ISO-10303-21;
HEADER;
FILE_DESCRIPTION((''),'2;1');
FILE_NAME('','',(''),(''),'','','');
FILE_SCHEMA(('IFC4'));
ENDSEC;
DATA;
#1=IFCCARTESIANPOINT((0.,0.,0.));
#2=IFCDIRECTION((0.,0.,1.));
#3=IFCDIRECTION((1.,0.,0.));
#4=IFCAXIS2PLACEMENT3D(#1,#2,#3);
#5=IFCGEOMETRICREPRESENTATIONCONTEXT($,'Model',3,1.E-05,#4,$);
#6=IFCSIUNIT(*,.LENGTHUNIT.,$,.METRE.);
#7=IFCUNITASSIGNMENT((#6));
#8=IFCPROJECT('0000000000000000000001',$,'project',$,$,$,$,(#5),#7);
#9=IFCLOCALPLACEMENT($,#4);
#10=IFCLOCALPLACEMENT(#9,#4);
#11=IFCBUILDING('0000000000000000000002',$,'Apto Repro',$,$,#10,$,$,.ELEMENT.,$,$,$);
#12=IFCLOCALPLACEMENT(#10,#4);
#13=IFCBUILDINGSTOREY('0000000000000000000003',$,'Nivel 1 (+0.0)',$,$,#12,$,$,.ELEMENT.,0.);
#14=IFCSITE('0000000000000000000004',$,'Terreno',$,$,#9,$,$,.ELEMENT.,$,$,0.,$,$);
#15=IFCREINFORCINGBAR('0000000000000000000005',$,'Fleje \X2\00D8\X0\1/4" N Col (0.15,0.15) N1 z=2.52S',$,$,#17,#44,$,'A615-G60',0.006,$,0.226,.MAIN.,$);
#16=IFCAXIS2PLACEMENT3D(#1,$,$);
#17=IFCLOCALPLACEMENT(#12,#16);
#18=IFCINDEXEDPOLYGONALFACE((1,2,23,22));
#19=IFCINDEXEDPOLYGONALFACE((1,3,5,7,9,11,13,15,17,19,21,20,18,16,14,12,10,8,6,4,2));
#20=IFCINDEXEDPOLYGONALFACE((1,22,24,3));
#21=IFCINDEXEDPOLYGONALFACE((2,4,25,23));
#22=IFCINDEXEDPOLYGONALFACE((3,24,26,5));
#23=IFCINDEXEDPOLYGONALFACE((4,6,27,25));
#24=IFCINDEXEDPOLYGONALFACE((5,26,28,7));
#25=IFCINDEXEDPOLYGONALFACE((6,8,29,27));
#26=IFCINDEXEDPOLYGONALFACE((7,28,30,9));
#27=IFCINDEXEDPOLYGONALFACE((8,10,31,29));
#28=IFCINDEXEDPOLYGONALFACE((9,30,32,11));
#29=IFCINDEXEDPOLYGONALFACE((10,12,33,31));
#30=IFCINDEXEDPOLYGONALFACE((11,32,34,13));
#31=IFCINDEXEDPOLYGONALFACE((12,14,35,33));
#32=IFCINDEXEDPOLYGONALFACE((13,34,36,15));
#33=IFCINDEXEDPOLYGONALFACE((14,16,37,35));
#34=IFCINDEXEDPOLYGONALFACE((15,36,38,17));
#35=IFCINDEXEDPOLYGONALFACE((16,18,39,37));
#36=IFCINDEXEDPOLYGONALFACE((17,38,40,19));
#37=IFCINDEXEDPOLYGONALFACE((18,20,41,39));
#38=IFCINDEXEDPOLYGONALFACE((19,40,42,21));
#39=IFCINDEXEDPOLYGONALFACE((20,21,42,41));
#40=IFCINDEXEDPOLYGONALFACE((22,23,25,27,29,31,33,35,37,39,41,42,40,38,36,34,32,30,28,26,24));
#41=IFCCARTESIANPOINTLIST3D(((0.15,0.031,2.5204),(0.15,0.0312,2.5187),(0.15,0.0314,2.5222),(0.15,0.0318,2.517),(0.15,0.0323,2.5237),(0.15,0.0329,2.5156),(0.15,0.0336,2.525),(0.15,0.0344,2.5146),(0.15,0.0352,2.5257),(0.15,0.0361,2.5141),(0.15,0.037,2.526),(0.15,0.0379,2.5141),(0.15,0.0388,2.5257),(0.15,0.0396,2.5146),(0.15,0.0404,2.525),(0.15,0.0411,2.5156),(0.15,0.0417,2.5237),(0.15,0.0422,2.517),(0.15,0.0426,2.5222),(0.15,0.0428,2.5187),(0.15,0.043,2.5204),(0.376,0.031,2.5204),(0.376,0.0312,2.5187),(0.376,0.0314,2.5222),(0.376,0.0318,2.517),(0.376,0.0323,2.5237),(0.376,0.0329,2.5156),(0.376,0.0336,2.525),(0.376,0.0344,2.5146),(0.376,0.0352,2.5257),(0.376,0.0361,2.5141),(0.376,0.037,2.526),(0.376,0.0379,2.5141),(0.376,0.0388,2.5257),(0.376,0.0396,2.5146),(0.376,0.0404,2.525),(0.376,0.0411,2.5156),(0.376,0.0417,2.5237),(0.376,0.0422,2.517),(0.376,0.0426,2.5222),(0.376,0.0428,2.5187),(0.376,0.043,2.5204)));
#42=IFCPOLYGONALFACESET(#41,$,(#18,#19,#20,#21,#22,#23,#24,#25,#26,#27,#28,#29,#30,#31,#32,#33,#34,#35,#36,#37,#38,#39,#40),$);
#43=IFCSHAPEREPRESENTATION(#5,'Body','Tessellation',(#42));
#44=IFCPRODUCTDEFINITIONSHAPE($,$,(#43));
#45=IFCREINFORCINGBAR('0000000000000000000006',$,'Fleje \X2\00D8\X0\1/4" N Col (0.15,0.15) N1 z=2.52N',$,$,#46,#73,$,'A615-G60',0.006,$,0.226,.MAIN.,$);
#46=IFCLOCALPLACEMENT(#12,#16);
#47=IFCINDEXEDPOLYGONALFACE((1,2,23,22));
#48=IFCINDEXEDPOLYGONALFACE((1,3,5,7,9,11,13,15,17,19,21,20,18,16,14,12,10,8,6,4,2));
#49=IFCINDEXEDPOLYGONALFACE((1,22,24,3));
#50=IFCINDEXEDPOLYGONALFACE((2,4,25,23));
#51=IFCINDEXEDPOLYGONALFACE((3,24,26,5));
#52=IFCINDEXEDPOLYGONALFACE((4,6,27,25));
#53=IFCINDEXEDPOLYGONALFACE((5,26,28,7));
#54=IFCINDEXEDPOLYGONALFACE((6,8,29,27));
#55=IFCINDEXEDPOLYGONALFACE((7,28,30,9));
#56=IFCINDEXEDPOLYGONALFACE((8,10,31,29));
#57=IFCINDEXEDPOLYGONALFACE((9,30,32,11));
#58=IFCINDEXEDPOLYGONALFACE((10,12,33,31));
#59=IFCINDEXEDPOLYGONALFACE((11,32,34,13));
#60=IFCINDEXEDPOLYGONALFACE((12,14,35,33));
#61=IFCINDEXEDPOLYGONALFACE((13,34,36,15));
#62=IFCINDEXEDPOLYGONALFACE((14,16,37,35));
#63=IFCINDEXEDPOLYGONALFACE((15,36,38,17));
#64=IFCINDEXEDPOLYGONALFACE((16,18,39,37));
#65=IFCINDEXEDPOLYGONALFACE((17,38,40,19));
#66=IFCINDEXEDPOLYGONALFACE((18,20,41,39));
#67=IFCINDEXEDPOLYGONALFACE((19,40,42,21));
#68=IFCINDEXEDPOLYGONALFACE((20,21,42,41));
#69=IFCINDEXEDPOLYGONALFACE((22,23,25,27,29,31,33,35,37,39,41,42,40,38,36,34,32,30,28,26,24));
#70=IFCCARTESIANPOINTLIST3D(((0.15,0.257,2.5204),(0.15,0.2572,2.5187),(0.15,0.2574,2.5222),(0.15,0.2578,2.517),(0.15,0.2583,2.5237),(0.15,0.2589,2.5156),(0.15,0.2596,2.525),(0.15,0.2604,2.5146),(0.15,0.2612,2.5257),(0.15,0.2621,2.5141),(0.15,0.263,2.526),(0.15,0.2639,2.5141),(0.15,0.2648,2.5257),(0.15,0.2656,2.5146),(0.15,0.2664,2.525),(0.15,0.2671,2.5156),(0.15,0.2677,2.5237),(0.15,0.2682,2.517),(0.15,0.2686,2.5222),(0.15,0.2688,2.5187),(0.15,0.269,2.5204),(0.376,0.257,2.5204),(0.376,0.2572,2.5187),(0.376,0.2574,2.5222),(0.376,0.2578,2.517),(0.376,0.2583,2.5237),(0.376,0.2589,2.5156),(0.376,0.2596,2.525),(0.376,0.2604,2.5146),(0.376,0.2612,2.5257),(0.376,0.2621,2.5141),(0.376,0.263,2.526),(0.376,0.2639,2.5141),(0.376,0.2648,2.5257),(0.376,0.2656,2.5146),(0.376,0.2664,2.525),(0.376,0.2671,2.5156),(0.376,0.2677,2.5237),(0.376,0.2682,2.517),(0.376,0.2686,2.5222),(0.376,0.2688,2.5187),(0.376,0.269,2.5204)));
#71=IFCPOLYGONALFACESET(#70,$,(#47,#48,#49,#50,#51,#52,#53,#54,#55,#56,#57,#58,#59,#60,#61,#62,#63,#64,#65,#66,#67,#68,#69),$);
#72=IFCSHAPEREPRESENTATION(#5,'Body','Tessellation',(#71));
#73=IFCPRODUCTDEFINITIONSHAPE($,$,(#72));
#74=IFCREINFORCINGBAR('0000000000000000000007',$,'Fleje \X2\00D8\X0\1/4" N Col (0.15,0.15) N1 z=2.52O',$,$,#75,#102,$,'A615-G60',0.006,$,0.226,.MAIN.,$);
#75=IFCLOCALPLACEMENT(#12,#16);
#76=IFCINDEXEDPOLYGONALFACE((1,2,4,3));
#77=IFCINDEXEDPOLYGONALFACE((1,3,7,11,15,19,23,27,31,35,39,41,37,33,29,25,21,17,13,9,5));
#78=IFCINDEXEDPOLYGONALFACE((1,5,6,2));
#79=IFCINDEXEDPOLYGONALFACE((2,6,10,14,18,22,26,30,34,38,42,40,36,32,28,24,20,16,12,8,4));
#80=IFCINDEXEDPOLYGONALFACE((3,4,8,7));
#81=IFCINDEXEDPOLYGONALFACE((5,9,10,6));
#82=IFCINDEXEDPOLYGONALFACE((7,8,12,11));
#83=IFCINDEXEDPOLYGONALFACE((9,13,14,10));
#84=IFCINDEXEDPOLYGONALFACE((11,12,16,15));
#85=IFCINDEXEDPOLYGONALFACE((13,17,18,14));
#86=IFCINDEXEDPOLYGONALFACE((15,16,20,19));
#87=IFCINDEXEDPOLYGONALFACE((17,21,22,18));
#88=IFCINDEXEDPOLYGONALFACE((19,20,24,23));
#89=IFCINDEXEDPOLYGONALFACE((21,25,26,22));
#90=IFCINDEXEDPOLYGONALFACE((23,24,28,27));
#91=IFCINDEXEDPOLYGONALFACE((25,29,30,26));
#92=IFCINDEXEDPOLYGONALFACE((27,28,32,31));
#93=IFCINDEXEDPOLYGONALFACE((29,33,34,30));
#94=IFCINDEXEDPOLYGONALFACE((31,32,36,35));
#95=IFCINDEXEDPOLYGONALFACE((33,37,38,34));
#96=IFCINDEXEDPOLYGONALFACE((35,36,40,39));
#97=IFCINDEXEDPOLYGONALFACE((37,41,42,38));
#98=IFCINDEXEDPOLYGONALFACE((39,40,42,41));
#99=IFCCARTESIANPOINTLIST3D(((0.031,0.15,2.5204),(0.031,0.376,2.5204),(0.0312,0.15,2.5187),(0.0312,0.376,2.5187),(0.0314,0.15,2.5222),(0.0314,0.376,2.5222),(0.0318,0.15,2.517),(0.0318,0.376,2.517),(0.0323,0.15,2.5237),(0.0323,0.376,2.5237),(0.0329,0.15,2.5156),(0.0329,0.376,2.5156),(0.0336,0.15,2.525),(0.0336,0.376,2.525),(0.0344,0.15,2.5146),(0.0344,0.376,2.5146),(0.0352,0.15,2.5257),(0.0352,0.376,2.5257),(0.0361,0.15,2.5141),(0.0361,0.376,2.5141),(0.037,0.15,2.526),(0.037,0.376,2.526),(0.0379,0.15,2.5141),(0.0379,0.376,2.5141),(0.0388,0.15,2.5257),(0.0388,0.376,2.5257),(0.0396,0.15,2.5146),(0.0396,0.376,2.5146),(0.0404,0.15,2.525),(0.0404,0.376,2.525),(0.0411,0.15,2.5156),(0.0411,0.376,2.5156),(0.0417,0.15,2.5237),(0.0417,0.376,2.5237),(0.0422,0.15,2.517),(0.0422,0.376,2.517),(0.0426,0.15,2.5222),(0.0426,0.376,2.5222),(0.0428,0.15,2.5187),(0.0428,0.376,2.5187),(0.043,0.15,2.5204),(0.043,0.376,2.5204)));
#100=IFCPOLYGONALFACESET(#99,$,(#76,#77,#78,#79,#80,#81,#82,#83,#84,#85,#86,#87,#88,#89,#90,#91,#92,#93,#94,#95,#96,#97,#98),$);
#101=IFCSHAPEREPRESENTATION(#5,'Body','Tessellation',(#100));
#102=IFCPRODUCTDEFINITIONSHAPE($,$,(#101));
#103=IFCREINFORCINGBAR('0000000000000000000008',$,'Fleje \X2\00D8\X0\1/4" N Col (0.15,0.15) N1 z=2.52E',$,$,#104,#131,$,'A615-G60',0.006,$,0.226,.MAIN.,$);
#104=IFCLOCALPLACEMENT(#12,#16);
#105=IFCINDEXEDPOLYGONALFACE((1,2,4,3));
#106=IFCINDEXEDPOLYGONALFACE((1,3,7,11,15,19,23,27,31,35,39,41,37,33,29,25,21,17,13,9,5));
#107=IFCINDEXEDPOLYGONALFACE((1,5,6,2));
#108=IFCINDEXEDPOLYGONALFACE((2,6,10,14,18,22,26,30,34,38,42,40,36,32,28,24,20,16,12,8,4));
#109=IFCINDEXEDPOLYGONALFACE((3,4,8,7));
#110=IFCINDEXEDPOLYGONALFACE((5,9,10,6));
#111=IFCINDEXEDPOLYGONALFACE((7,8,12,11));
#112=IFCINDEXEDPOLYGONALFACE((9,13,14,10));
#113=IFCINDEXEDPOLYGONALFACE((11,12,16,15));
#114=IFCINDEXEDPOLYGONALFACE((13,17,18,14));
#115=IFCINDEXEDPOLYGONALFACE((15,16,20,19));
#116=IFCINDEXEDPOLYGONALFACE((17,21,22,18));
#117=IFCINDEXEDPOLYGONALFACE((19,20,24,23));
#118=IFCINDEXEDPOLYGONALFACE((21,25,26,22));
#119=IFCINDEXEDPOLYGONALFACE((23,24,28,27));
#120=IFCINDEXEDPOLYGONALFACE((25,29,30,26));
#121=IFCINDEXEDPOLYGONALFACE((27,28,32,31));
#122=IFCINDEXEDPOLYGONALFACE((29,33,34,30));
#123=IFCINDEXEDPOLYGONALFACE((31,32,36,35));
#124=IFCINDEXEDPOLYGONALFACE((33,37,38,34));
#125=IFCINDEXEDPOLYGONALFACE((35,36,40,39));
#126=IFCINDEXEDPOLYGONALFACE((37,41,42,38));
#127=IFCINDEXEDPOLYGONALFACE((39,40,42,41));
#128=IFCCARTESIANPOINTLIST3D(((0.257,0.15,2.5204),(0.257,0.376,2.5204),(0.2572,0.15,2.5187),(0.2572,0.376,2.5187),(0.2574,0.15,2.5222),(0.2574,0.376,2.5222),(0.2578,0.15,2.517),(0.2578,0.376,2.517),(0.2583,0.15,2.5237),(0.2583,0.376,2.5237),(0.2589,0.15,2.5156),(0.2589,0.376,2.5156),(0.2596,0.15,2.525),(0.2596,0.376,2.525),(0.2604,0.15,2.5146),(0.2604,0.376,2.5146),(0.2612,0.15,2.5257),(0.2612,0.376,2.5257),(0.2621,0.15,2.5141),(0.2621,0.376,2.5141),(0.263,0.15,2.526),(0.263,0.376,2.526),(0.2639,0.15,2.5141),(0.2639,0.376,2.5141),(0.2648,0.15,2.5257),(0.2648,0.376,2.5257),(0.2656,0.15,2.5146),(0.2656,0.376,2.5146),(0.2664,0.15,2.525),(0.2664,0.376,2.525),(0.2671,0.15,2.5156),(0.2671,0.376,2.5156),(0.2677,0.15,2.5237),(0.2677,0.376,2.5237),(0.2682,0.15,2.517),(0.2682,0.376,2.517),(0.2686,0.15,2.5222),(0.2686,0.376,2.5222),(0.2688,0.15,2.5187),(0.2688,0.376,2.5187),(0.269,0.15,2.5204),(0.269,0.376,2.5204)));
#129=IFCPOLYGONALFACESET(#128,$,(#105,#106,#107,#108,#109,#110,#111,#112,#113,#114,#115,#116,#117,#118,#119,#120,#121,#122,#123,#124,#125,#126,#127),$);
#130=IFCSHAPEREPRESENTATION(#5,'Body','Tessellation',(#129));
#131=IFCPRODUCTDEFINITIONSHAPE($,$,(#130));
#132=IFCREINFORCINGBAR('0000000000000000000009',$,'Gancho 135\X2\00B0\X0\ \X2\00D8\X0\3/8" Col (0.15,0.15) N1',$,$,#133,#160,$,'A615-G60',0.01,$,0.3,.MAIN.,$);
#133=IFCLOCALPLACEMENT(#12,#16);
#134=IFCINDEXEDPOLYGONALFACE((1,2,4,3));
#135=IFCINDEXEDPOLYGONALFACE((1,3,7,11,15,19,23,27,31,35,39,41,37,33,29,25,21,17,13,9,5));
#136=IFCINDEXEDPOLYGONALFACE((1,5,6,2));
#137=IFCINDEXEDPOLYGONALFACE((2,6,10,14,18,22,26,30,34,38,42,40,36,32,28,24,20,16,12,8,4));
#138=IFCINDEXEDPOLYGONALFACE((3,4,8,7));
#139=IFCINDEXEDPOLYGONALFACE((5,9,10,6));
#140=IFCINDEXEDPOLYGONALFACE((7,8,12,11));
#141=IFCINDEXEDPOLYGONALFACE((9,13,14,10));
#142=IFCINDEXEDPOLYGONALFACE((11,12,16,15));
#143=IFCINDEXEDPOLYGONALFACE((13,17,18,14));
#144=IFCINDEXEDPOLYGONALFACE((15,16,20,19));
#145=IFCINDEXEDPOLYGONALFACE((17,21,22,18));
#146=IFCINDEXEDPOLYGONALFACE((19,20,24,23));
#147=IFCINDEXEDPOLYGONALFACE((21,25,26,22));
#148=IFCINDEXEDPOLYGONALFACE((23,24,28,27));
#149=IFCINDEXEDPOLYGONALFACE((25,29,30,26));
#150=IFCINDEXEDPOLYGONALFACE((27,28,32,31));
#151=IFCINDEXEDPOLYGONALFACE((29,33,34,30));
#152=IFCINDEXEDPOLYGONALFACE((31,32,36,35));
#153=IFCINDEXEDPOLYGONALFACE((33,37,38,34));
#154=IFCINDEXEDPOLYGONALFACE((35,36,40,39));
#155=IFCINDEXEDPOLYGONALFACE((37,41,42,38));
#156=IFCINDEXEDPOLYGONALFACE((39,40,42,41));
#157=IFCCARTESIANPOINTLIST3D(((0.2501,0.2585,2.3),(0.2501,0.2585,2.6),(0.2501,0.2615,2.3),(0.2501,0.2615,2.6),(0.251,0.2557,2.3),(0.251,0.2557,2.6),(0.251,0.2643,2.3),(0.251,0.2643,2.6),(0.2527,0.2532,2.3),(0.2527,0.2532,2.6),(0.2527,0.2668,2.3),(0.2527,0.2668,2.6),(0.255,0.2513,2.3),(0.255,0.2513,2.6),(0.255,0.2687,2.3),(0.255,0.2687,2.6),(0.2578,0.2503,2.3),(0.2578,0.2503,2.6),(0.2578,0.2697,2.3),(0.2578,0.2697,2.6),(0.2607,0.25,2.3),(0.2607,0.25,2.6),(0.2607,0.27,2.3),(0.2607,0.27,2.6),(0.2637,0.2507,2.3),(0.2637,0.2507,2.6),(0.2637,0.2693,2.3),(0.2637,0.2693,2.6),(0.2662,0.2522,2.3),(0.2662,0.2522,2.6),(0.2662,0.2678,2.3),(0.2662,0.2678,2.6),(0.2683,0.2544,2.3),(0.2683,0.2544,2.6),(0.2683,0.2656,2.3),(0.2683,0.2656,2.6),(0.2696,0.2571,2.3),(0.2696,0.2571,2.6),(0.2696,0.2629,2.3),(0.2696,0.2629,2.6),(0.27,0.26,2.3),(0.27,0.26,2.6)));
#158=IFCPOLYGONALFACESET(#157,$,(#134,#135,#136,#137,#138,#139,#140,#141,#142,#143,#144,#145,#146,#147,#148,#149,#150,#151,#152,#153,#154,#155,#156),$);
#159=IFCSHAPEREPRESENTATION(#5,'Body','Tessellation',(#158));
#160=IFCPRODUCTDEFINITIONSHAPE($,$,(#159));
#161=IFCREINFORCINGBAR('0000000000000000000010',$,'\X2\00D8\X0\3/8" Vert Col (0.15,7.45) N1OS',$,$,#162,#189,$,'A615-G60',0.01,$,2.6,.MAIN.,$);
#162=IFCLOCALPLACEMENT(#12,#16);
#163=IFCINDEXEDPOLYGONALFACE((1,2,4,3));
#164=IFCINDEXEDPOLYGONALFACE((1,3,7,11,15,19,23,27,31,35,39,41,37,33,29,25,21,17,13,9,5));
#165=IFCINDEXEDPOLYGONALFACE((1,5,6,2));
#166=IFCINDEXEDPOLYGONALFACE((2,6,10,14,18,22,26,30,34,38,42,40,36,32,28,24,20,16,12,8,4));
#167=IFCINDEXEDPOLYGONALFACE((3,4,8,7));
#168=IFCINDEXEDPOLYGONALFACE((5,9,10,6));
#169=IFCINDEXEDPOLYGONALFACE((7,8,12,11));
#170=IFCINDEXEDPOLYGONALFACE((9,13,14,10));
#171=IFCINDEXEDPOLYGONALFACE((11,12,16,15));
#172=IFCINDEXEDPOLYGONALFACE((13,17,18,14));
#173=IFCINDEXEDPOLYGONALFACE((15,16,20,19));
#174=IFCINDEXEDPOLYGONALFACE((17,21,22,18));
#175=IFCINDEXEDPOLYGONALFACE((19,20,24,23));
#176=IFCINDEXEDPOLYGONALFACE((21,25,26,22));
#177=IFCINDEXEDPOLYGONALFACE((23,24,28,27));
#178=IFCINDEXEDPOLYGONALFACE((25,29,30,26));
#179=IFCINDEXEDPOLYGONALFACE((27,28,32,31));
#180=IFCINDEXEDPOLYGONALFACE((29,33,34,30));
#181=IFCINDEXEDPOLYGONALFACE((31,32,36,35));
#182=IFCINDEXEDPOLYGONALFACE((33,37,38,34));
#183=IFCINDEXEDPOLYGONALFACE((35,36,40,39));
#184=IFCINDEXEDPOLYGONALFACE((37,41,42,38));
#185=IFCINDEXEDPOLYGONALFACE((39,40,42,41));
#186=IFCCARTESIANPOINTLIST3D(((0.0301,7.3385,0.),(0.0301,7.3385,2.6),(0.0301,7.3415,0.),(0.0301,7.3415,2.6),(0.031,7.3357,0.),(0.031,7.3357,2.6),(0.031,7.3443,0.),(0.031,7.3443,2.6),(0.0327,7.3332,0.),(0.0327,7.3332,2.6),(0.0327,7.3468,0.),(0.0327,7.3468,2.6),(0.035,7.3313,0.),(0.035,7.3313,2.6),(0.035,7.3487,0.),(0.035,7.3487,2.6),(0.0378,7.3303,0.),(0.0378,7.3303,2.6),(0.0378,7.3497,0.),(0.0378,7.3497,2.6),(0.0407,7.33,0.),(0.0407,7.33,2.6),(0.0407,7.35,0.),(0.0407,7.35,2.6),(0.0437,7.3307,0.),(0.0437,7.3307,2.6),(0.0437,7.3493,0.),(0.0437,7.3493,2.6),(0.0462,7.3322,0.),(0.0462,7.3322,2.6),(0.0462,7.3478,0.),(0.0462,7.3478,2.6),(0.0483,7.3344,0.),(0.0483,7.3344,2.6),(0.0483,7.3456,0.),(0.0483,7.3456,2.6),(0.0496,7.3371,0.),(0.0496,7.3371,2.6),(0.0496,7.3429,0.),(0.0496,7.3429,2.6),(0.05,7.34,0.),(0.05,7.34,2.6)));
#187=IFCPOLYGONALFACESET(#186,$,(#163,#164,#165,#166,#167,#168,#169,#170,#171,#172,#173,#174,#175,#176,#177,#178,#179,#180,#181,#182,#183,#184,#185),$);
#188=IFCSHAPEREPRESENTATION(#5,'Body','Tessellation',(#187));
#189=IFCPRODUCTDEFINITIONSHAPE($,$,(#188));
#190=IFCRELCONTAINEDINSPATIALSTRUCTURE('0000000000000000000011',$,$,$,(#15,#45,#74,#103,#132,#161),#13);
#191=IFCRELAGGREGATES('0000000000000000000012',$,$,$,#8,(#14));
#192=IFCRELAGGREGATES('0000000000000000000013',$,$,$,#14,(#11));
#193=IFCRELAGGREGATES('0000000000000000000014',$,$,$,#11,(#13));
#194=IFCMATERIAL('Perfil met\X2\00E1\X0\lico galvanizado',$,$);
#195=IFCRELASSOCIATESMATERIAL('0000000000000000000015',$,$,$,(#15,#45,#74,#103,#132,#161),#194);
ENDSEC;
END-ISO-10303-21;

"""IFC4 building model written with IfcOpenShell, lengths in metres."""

from ifc_helpers import new_model, si_unit, frame, origin_with_axes, origin_2d_with_axis, place, context, project, spatial, circle, extrude, material, element, save


model = new_model("IFC4")

# Units and contexts
model_context = context("Model", 3, precision=1e-05, world=origin_with_axes())
ifc_project = project(units=[si_unit("LENGTHUNIT", "METRE")], contexts=[model_context])

# Site, building, storey
site_placement = place(None, origin_with_axes())
site = spatial("IfcSite", under=ifc_project, at=site_placement, Name="Terreno", CompositionType="ELEMENT", RefElevation=0.0)
building_placement = place(site_placement, origin_with_axes())
building = spatial("IfcBuilding", under=site, at=building_placement, Name="Apto Repro", CompositionType="ELEMENT")
storey_placement = place(building_placement, origin_with_axes())
storey = spatial("IfcBuildingStorey", under=building, at=storey_placement, Name="Nivel 1 (+0.0)", CompositionType="ELEMENT", Elevation=0.0)

# Reinforcing bars
ifc_material = material(Name="Perfil metálico galvanizado")
reinforcing_bar_1_placement = place(storey_placement, origin_with_axes())
element("IfcReinforcingBar", 1, at=reinforcing_bar_1_placement, inside=storey, material=ifc_material, Name="Fleje Ø1/4\" N Col (0.15,0.15) N1 z=2.52S", SteelGrade="A615-G60", BarLength=0.226, NominalDiameter=0.006, PredefinedType="MAIN", context=model_context, shape_type="SweptSolid", body=[
    extrude(circle(Radius=0.006, at=origin_2d_with_axis()), frame((0.15, 0.037, 2.52), z_axis=(1.0, 0.0, 0.0), x_axis=(0.0, 0.0, 1.0)), (0.0, 0.0, 1.0), 0.226),
])
reinforcing_bar_2_placement = place(storey_placement, origin_with_axes())
element("IfcReinforcingBar", 2, at=reinforcing_bar_2_placement, inside=storey, material=ifc_material, Name="Fleje Ø1/4\" N Col (0.15,0.15) N1 z=2.52N", SteelGrade="A615-G60", BarLength=0.226, NominalDiameter=0.006, PredefinedType="MAIN", context=model_context, shape_type="SweptSolid", body=[
    extrude(circle(Radius=0.006, at=origin_2d_with_axis()), frame((0.15, 0.263, 2.52), z_axis=(1.0, 0.0, 0.0), x_axis=(0.0, 0.0, 1.0)), (0.0, 0.0, 1.0), 0.226),
])
reinforcing_bar_3_placement = place(storey_placement, origin_with_axes())
element("IfcReinforcingBar", 3, at=reinforcing_bar_3_placement, inside=storey, material=ifc_material, Name="Fleje Ø1/4\" N Col (0.15,0.15) N1 z=2.52O", SteelGrade="A615-G60", BarLength=0.226, NominalDiameter=0.006, PredefinedType="MAIN", context=model_context, shape_type="SweptSolid", body=[
    extrude(circle(Radius=0.006, at=origin_2d_with_axis()), frame((0.037, 0.15, 2.52), z_axis=(0.0, 1.0, 0.0), x_axis=(0.0, 0.0, 1.0)), (0.0, 0.0, 1.0), 0.226),
])
reinforcing_bar_4_placement = place(storey_placement, origin_with_axes())
element("IfcReinforcingBar", 4, at=reinforcing_bar_4_placement, inside=storey, material=ifc_material, Name="Fleje Ø1/4\" N Col (0.15,0.15) N1 z=2.52E", SteelGrade="A615-G60", BarLength=0.226, NominalDiameter=0.006, PredefinedType="MAIN", context=model_context, shape_type="SweptSolid", body=[
    extrude(circle(Radius=0.006, at=origin_2d_with_axis()), frame((0.263, 0.15, 2.52), z_axis=(0.0, 1.0, 0.0), x_axis=(0.0, 0.0, 1.0)), (0.0, 0.0, 1.0), 0.226),
])
reinforcing_bar_5_placement = place(storey_placement, origin_with_axes())
element("IfcReinforcingBar", 5, at=reinforcing_bar_5_placement, inside=storey, material=ifc_material, Name="Gancho 135° Ø3/8\" Col (0.15,0.15) N1", SteelGrade="A615-G60", BarLength=0.3, NominalDiameter=0.01, PredefinedType="MAIN", context=model_context, shape_type="SweptSolid", body=[
    extrude(circle(Radius=0.01, at=origin_2d_with_axis()), frame((0.26, 0.26, 2.3), z_axis=(0.0, 0.0, 1.0), x_axis=(1.0, 0.0, 0.0)), (0.0, 0.0, 1.0), 0.3),
])
reinforcing_bar_6_placement = place(storey_placement, origin_with_axes())
element("IfcReinforcingBar", 6, at=reinforcing_bar_6_placement, inside=storey, material=ifc_material, Name="Ø3/8\" Vert Col (0.15,7.45) N1OS", SteelGrade="A615-G60", BarLength=2.6, NominalDiameter=0.01, PredefinedType="MAIN", context=model_context, shape_type="SweptSolid", body=[
    extrude(circle(Radius=0.01, at=origin_2d_with_axis()), frame((0.04, 7.34, 0.0), z_axis=(0.0, 0.0, 1.0), x_axis=(1.0, 0.0, 0.0)), (0.0, 0.0, 1.0), 2.6),
])

save(model, "model.ifc")
